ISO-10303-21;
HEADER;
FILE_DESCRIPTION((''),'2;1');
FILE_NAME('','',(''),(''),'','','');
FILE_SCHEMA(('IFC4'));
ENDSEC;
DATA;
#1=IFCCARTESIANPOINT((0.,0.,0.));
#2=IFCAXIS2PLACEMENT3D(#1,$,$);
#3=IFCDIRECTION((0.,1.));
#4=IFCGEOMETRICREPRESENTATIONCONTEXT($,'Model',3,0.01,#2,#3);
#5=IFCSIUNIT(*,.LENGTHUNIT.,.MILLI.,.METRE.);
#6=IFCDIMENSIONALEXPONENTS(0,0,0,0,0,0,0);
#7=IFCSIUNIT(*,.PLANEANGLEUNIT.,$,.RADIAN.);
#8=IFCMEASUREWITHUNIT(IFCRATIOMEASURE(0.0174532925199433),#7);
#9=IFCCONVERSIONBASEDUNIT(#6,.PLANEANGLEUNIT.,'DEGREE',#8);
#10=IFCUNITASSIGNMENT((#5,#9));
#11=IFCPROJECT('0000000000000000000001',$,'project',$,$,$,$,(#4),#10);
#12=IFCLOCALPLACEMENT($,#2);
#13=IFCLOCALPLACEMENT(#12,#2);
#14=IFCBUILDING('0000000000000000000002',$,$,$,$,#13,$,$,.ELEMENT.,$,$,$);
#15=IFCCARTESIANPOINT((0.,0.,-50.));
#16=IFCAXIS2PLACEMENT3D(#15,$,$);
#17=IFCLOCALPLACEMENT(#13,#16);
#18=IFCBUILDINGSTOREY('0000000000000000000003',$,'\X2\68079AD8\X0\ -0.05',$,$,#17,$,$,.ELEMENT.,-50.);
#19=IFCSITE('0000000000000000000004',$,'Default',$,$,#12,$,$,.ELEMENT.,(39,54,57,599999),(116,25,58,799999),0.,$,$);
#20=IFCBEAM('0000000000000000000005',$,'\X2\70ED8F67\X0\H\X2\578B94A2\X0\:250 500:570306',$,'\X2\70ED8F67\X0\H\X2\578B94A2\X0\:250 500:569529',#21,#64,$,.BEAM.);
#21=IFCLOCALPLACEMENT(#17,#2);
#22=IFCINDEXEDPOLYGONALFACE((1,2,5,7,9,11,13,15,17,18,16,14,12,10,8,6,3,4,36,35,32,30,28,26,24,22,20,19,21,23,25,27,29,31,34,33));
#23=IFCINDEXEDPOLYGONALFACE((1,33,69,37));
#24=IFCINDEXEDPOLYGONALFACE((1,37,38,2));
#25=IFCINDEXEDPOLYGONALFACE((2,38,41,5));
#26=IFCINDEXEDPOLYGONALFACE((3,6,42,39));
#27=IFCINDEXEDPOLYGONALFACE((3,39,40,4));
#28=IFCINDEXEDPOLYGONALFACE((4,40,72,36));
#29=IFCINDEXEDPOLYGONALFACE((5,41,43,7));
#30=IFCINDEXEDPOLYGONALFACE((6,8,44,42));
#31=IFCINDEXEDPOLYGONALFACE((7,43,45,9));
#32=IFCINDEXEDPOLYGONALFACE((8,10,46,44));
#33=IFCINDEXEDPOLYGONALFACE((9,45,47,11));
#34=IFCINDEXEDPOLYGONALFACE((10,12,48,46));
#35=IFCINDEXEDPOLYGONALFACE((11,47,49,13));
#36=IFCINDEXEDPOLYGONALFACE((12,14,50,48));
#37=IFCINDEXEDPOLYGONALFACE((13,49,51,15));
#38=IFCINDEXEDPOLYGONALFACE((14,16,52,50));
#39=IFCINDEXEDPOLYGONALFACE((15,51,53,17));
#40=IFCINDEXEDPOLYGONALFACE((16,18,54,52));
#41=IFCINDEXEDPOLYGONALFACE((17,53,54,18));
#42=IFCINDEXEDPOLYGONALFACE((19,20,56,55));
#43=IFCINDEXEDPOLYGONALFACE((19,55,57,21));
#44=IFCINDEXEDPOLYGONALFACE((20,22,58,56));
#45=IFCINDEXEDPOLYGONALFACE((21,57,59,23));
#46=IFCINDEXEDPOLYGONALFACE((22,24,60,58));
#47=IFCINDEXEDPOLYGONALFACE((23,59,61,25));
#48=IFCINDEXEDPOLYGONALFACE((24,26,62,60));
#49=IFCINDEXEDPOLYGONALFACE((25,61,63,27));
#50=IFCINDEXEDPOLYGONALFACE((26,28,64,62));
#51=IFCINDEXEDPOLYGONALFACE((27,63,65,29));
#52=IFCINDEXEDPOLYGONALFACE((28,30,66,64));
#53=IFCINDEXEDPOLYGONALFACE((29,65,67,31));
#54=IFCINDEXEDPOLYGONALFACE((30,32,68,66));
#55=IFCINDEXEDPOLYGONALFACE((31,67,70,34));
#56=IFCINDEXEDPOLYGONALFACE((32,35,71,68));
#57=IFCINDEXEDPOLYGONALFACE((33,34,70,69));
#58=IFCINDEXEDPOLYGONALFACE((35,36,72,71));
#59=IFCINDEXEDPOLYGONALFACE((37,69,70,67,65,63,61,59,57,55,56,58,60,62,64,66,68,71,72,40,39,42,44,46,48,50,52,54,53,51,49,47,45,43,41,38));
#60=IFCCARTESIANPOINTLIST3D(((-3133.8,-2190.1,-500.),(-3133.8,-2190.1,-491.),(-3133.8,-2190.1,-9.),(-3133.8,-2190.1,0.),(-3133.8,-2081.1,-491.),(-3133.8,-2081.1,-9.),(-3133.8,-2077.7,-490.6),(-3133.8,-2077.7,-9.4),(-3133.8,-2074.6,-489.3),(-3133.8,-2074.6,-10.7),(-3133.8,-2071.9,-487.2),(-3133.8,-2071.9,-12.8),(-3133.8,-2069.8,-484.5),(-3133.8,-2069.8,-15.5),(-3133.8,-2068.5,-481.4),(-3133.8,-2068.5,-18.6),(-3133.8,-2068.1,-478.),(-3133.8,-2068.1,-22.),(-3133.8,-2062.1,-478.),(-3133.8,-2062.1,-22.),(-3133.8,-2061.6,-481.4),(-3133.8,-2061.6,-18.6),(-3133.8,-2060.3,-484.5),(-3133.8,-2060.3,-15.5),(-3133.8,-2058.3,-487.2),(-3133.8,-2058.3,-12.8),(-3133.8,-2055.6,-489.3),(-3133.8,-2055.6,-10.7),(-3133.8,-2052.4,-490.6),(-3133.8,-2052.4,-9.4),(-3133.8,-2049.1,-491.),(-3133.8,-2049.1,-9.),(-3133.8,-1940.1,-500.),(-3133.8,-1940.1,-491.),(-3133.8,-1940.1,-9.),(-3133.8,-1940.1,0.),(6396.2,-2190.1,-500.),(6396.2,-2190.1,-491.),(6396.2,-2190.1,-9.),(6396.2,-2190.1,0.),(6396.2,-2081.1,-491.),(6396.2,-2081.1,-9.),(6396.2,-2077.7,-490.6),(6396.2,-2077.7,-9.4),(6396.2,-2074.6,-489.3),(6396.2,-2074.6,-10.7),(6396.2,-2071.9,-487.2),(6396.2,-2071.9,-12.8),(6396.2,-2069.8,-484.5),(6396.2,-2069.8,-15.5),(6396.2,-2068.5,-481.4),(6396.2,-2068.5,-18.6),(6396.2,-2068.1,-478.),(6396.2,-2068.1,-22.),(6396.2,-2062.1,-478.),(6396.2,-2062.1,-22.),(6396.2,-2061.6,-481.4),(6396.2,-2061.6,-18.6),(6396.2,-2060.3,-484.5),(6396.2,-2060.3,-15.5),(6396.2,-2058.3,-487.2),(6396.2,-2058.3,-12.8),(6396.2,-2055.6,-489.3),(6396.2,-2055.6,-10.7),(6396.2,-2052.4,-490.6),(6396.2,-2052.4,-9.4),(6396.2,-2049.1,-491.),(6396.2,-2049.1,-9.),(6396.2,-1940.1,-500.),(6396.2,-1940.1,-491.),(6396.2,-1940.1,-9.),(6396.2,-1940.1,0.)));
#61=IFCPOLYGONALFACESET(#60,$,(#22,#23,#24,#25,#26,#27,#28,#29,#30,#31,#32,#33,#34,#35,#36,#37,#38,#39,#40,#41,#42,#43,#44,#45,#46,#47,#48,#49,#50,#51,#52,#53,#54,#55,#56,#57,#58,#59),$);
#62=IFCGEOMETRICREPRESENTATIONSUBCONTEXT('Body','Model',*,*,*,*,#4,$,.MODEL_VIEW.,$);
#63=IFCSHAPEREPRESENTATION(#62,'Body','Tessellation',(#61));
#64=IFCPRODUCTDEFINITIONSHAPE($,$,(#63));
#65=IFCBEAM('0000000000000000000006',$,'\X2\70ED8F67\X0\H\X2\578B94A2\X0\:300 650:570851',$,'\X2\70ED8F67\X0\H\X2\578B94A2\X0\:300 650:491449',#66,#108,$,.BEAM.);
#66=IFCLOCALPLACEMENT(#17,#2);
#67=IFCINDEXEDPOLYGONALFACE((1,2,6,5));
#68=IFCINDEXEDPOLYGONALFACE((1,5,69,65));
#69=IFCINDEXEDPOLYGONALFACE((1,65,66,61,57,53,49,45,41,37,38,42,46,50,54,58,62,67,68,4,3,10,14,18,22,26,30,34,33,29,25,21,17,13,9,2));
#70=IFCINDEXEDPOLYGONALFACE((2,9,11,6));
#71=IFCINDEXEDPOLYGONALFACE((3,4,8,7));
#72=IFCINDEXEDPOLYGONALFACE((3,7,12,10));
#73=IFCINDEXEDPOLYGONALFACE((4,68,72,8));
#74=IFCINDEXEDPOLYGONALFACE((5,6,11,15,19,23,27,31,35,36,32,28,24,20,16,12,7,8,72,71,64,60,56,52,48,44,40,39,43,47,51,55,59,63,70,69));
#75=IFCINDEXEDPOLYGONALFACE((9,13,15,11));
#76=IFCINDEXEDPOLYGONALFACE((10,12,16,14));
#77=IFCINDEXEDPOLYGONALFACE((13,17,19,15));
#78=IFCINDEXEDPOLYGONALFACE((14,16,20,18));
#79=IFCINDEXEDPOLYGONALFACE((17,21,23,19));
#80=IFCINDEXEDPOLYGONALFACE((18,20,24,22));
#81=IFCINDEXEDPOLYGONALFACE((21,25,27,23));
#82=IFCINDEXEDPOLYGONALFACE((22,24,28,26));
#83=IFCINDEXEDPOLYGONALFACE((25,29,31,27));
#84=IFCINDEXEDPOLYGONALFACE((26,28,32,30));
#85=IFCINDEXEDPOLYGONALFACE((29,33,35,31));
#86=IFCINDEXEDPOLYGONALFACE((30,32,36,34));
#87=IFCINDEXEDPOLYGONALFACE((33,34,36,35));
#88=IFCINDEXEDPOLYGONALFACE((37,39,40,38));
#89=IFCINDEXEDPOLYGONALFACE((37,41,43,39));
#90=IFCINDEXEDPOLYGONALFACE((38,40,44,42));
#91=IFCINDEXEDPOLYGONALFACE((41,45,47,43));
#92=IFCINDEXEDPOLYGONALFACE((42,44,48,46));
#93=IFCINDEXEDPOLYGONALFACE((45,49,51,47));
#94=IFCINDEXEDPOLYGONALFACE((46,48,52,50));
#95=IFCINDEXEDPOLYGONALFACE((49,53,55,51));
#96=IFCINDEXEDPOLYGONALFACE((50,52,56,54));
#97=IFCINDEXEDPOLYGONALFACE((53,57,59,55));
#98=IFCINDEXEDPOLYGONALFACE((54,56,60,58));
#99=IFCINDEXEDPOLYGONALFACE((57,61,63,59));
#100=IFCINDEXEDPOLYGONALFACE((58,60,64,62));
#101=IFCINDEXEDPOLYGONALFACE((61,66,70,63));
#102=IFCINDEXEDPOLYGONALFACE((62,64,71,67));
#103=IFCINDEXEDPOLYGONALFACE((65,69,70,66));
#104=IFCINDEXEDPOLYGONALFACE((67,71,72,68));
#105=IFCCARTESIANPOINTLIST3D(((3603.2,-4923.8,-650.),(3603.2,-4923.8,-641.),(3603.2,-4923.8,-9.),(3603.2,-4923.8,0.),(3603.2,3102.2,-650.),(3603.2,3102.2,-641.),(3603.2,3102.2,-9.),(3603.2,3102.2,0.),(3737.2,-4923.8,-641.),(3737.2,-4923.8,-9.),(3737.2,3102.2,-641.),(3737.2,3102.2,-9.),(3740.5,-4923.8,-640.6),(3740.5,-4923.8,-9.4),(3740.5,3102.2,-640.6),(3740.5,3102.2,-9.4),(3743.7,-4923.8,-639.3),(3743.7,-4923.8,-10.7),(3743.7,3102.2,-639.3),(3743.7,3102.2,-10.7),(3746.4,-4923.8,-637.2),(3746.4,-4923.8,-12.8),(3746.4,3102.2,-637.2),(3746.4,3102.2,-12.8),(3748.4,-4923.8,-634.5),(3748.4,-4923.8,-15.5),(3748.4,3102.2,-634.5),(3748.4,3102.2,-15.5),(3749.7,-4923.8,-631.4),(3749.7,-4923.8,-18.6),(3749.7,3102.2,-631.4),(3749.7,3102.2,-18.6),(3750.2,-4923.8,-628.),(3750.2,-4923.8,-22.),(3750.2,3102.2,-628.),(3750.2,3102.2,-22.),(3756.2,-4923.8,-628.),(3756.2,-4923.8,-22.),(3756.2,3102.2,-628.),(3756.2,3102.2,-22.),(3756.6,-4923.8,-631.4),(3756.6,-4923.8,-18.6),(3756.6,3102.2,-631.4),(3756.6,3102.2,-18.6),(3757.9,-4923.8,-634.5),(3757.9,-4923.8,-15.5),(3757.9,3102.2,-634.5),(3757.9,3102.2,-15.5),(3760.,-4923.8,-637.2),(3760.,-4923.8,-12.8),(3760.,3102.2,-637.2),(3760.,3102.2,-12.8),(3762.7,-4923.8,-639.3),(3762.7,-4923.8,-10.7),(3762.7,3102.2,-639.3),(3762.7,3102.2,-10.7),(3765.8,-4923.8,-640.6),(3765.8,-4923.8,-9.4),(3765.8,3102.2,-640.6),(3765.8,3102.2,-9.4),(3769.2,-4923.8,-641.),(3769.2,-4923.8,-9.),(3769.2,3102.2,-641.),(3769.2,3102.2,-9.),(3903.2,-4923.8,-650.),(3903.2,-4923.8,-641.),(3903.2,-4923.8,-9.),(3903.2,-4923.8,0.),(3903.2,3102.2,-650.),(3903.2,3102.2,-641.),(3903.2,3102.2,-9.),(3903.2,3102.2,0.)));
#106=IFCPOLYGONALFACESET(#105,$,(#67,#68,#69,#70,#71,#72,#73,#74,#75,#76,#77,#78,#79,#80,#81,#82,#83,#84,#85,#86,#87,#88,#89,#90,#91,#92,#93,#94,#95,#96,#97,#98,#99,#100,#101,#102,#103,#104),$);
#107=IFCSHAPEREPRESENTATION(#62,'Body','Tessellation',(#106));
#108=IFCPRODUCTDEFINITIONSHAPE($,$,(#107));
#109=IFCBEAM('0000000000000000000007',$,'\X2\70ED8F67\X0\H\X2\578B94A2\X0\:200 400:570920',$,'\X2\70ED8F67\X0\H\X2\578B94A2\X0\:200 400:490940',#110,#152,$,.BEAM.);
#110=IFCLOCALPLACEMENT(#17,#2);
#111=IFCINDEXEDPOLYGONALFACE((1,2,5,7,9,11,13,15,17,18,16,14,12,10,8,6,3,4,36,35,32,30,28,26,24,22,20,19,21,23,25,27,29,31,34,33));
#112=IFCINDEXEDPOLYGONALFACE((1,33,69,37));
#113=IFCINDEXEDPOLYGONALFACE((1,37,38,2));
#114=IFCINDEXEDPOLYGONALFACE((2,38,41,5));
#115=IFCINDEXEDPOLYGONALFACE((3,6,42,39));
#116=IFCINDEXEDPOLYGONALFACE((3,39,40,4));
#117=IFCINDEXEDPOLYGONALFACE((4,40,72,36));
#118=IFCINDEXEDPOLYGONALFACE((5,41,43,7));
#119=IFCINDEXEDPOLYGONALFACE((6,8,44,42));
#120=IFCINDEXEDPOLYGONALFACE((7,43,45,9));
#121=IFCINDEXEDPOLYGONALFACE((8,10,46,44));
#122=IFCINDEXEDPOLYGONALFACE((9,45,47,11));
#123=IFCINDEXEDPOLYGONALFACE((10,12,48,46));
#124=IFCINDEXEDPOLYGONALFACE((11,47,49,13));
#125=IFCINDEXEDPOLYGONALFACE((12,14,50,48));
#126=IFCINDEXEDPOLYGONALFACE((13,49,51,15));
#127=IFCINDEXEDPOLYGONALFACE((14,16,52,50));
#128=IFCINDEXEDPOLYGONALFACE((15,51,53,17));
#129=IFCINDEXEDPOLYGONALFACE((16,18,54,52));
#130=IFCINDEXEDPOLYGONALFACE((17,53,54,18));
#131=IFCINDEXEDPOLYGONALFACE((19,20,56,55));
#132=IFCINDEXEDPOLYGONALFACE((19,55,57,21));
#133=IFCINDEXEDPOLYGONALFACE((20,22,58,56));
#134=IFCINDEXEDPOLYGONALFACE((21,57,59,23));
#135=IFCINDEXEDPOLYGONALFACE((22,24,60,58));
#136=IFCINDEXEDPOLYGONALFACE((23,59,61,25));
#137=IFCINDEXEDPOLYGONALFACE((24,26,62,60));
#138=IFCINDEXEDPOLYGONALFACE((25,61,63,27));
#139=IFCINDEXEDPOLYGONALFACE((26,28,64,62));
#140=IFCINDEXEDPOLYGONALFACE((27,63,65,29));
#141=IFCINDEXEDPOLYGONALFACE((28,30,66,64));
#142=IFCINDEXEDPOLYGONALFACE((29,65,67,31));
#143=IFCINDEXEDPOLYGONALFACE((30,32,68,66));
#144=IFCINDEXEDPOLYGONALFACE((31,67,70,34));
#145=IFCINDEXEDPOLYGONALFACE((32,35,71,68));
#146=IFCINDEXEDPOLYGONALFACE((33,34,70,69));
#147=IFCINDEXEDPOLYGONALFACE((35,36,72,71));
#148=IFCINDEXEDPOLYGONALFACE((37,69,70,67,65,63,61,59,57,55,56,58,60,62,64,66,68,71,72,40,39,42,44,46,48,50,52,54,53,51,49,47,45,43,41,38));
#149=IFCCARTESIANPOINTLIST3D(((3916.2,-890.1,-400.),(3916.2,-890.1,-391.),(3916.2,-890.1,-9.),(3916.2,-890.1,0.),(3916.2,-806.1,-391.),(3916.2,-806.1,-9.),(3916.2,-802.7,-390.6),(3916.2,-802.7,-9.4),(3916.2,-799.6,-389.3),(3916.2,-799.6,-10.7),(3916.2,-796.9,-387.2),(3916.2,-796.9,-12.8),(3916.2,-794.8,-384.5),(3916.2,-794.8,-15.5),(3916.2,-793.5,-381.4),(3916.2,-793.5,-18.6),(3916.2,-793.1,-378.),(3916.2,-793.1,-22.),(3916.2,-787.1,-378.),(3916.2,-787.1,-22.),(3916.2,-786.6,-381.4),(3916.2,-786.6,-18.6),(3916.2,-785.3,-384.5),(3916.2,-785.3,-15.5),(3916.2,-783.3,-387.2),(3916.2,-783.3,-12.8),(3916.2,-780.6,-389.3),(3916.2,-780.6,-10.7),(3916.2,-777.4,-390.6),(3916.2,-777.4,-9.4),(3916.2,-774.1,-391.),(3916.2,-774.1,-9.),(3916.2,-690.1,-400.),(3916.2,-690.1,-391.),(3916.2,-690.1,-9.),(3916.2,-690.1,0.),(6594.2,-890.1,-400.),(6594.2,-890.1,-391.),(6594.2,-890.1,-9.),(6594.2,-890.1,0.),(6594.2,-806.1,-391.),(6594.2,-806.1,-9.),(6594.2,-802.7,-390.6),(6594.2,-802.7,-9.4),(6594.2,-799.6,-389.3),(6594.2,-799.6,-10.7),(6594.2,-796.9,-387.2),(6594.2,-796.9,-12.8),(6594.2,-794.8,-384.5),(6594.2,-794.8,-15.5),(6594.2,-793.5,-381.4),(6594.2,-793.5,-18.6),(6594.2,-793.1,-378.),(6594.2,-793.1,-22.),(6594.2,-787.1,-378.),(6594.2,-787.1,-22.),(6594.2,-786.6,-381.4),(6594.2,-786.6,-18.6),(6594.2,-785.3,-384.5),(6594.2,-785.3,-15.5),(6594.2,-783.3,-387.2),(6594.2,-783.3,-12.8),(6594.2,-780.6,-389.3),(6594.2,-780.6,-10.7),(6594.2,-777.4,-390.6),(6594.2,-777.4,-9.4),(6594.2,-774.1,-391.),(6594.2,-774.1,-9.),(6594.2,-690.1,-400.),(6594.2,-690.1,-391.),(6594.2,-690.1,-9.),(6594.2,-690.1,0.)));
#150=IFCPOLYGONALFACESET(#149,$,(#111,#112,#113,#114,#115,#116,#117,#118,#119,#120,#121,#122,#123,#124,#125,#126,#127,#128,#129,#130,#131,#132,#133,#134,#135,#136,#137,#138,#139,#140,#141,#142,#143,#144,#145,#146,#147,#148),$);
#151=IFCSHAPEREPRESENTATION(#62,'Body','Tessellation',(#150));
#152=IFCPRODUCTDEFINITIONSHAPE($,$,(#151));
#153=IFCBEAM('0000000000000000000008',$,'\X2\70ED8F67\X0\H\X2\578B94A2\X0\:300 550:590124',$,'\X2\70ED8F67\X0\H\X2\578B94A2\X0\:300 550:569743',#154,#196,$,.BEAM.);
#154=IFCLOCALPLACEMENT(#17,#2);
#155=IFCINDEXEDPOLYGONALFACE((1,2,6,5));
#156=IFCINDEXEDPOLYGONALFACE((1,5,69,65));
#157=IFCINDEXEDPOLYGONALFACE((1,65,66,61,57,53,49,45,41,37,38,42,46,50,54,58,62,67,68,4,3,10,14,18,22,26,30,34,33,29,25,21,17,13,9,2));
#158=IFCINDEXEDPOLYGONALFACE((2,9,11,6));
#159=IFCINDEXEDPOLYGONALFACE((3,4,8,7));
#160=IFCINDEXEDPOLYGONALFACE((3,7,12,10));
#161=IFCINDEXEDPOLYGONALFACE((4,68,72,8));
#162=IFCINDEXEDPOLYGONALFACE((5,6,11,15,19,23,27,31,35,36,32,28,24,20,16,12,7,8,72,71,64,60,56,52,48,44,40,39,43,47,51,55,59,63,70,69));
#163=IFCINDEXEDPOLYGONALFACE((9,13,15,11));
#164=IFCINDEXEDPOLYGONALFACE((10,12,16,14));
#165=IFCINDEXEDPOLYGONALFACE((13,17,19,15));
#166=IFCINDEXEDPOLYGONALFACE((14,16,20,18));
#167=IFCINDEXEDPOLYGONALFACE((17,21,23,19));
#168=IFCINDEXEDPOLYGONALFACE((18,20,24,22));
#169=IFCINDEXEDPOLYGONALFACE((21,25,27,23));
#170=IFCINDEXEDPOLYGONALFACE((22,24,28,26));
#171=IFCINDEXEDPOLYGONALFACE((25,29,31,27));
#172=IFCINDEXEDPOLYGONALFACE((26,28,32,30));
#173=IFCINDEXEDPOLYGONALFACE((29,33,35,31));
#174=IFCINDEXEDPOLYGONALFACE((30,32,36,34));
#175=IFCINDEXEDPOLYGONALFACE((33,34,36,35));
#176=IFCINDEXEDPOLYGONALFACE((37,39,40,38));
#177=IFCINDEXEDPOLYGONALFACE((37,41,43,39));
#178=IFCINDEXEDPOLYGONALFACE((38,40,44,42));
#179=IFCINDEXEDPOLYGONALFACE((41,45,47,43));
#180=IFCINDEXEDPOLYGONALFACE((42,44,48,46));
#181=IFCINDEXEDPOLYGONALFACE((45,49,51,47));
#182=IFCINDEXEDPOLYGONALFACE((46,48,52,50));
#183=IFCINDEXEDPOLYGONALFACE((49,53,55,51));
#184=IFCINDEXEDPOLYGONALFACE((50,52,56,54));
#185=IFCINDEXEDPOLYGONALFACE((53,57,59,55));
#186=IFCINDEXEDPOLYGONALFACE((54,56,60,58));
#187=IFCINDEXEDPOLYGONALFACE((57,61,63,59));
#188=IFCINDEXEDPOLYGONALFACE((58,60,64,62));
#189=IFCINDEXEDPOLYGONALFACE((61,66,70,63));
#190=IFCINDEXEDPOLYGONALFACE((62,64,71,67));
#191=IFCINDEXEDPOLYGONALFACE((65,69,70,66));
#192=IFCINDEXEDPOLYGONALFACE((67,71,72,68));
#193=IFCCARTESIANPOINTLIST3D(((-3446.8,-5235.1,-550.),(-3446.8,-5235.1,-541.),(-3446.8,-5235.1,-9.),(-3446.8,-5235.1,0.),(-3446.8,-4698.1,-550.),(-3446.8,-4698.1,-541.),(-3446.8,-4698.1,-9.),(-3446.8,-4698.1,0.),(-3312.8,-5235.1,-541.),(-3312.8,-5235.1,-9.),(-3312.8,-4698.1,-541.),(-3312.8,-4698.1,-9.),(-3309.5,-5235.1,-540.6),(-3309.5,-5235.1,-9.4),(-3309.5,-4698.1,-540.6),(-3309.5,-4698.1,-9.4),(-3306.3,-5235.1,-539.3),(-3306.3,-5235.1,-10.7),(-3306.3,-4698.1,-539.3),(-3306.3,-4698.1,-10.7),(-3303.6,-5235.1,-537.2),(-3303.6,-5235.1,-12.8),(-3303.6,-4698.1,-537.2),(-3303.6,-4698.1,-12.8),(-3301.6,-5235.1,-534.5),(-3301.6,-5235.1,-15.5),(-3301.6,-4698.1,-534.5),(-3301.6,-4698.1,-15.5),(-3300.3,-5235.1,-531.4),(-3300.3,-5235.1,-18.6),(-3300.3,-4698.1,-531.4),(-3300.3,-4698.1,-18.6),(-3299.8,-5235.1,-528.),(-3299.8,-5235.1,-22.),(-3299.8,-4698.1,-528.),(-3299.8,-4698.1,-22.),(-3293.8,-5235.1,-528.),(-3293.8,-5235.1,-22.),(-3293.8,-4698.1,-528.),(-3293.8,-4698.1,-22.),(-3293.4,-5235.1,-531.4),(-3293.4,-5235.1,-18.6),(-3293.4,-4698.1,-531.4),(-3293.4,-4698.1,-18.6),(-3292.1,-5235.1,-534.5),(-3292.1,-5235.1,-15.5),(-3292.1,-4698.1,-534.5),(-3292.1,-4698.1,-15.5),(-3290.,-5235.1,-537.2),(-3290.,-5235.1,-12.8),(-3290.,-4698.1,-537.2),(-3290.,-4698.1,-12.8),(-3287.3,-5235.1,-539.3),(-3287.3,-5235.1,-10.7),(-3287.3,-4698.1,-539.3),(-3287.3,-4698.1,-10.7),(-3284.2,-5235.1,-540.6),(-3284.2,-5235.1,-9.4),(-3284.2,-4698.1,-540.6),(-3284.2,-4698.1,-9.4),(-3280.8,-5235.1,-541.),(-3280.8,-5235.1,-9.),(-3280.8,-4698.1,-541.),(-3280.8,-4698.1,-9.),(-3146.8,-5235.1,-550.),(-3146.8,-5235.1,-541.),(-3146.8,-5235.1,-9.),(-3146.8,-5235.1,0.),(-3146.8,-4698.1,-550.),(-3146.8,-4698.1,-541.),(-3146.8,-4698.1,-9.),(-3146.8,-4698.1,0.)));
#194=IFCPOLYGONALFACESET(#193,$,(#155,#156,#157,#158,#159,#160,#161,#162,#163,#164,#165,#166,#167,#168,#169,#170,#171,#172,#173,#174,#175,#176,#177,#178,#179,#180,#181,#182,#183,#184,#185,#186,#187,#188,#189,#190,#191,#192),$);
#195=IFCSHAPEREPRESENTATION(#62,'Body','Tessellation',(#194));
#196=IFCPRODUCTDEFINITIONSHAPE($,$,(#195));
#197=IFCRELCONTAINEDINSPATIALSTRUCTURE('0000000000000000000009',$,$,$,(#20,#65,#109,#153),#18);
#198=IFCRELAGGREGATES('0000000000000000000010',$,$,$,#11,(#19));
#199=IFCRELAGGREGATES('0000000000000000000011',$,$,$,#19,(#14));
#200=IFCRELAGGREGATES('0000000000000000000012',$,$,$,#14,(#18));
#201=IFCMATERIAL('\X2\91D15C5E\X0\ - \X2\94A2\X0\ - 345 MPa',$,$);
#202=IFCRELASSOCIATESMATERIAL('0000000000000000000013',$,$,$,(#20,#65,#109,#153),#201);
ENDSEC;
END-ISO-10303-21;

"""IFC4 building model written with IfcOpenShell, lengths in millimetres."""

from ifc_helpers import new_model, entity, si_unit, converted_unit, direction, frame, frame_2d, origin, place, context, subcontext, project, spatial, i_section, extrude, material, element, save


model = new_model("IFC4")

# Units and contexts
model_context = context("Model", 3, precision=0.01, world=origin(), true_north=direction((0.0, 1.0)))
body_context = subcontext(model_context, "Body", "Model", "MODEL_VIEW")
ifc_project = project(units=[si_unit("LENGTHUNIT", "METRE", prefix="MILLI"), converted_unit("PLANEANGLEUNIT", "DEGREE", entity("IfcRatioMeasure", 0.0174532925199433), si_unit("PLANEANGLEUNIT", "RADIAN"), dimensions=[0, 0, 0, 0, 0, 0, 0])], contexts=[model_context])

# Site, building, storey
site_placement = place(None, origin())
site = spatial("IfcSite", under=ifc_project, at=site_placement, Name="Default", CompositionType="ELEMENT", RefLatitude=(39, 54, 57, 599999), RefLongitude=(116, 25, 58, 799999), RefElevation=0.0)
building_placement = place(site_placement, origin())
building = spatial("IfcBuilding", under=site, at=building_placement, CompositionType="ELEMENT")
storey_placement = place(building_placement, frame((0.0, 0.0, -50.0)))
storey = spatial("IfcBuildingStorey", under=building, at=storey_placement, Name="标高 -0.05", CompositionType="ELEMENT", Elevation=-50.0)

# Beams
ifc_material_1 = material(Name="金属 - 钢 - 345 MPa")
beam_1_placement = place(storey_placement, frame((-3296.8, -2065.1, 0.0)))
element("IfcBeam", 1, at=beam_1_placement, inside=storey, material=ifc_material_1, Name="热轧H型钢:250 500:570306", ObjectType="热轧H型钢:250 500:569529", PredefinedType="BEAM", context=body_context, shape_type="SweptSolid", body=[
    extrude(i_section(OverallWidth=250.0, OverallDepth=500.0, WebThickness=6.0, FlangeThickness=9.0, FilletRadius=13.0, at=frame_2d((0.0, 0.0), x_axis=(0.0, 1.0))), frame((163.0, 0.0, -250.0), z_axis=(1.0, 0.0, 0.0), x_axis=(0.0, 0.0, -1.0)), (0.0, 0.0, 1.0), 9530.0),
])
beam_2_placement = place(storey_placement, frame((3753.2, -5086.6, 0.0), z_axis=(0.0, 0.0, 1.0), x_axis=(0.0, 1.0, 0.0)))
element("IfcBeam", 2, at=beam_2_placement, inside=storey, material=ifc_material_1, Name="热轧H型钢:300 650:570851", ObjectType="热轧H型钢:300 650:491449", PredefinedType="BEAM", context=body_context, shape_type="SweptSolid", body=[
    extrude(i_section(OverallWidth=300.0, OverallDepth=650.0, WebThickness=6.0, FlangeThickness=9.0, FilletRadius=13.0, at=frame_2d((0.0, 0.0), x_axis=(0.0, 1.0))), frame((162.8, 0.0, -325.0), z_axis=(1.0, 0.0, 0.0), x_axis=(0.0, 0.0, -1.0)), (0.0, 0.0, 1.0), 8026.0),
])
beam_3_placement = place(storey_placement, frame((3753.2, -790.1, 0.0)))
element("IfcBeam", 3, at=beam_3_placement, inside=storey, material=ifc_material_1, Name="热轧H型钢:200 400:570920", ObjectType="热轧H型钢:200 400:490940", PredefinedType="BEAM", context=body_context, shape_type="SweptSolid", body=[
    extrude(i_section(OverallWidth=200.0, OverallDepth=400.0, WebThickness=6.0, FlangeThickness=9.0, FilletRadius=13.0, at=frame_2d((0.0, 0.0), x_axis=(0.0, 1.0))), frame((163.0, 0.0, -200.0), z_axis=(1.0, 0.0, 0.0), x_axis=(0.0, 0.0, -1.0)), (0.0, 0.0, 1.0), 2678.0),
])
beam_4_placement = place(storey_placement, frame((-3296.8, -4190.1, 0.0), z_axis=(0.0, 0.0, 1.0), x_axis=(0.0, -1.0, 0.0)))
element("IfcBeam", 4, at=beam_4_placement, inside=storey, material=ifc_material_1, Name="热轧H型钢:300 550:590124", ObjectType="热轧H型钢:300 550:569743", PredefinedType="BEAM", context=body_context, shape_type="SweptSolid", body=[
    extrude(i_section(OverallWidth=300.0, OverallDepth=550.0, WebThickness=6.0, FlangeThickness=9.0, FilletRadius=13.0, at=frame_2d((0.0, 0.0), x_axis=(0.0, 1.0))), frame((508.0, 0.0, -275.0), z_axis=(1.0, 0.0, 0.0), x_axis=(0.0, 0.0, -1.0)), (0.0, 0.0, 1.0), 537.0),
])

save(model, "model.ifc")
